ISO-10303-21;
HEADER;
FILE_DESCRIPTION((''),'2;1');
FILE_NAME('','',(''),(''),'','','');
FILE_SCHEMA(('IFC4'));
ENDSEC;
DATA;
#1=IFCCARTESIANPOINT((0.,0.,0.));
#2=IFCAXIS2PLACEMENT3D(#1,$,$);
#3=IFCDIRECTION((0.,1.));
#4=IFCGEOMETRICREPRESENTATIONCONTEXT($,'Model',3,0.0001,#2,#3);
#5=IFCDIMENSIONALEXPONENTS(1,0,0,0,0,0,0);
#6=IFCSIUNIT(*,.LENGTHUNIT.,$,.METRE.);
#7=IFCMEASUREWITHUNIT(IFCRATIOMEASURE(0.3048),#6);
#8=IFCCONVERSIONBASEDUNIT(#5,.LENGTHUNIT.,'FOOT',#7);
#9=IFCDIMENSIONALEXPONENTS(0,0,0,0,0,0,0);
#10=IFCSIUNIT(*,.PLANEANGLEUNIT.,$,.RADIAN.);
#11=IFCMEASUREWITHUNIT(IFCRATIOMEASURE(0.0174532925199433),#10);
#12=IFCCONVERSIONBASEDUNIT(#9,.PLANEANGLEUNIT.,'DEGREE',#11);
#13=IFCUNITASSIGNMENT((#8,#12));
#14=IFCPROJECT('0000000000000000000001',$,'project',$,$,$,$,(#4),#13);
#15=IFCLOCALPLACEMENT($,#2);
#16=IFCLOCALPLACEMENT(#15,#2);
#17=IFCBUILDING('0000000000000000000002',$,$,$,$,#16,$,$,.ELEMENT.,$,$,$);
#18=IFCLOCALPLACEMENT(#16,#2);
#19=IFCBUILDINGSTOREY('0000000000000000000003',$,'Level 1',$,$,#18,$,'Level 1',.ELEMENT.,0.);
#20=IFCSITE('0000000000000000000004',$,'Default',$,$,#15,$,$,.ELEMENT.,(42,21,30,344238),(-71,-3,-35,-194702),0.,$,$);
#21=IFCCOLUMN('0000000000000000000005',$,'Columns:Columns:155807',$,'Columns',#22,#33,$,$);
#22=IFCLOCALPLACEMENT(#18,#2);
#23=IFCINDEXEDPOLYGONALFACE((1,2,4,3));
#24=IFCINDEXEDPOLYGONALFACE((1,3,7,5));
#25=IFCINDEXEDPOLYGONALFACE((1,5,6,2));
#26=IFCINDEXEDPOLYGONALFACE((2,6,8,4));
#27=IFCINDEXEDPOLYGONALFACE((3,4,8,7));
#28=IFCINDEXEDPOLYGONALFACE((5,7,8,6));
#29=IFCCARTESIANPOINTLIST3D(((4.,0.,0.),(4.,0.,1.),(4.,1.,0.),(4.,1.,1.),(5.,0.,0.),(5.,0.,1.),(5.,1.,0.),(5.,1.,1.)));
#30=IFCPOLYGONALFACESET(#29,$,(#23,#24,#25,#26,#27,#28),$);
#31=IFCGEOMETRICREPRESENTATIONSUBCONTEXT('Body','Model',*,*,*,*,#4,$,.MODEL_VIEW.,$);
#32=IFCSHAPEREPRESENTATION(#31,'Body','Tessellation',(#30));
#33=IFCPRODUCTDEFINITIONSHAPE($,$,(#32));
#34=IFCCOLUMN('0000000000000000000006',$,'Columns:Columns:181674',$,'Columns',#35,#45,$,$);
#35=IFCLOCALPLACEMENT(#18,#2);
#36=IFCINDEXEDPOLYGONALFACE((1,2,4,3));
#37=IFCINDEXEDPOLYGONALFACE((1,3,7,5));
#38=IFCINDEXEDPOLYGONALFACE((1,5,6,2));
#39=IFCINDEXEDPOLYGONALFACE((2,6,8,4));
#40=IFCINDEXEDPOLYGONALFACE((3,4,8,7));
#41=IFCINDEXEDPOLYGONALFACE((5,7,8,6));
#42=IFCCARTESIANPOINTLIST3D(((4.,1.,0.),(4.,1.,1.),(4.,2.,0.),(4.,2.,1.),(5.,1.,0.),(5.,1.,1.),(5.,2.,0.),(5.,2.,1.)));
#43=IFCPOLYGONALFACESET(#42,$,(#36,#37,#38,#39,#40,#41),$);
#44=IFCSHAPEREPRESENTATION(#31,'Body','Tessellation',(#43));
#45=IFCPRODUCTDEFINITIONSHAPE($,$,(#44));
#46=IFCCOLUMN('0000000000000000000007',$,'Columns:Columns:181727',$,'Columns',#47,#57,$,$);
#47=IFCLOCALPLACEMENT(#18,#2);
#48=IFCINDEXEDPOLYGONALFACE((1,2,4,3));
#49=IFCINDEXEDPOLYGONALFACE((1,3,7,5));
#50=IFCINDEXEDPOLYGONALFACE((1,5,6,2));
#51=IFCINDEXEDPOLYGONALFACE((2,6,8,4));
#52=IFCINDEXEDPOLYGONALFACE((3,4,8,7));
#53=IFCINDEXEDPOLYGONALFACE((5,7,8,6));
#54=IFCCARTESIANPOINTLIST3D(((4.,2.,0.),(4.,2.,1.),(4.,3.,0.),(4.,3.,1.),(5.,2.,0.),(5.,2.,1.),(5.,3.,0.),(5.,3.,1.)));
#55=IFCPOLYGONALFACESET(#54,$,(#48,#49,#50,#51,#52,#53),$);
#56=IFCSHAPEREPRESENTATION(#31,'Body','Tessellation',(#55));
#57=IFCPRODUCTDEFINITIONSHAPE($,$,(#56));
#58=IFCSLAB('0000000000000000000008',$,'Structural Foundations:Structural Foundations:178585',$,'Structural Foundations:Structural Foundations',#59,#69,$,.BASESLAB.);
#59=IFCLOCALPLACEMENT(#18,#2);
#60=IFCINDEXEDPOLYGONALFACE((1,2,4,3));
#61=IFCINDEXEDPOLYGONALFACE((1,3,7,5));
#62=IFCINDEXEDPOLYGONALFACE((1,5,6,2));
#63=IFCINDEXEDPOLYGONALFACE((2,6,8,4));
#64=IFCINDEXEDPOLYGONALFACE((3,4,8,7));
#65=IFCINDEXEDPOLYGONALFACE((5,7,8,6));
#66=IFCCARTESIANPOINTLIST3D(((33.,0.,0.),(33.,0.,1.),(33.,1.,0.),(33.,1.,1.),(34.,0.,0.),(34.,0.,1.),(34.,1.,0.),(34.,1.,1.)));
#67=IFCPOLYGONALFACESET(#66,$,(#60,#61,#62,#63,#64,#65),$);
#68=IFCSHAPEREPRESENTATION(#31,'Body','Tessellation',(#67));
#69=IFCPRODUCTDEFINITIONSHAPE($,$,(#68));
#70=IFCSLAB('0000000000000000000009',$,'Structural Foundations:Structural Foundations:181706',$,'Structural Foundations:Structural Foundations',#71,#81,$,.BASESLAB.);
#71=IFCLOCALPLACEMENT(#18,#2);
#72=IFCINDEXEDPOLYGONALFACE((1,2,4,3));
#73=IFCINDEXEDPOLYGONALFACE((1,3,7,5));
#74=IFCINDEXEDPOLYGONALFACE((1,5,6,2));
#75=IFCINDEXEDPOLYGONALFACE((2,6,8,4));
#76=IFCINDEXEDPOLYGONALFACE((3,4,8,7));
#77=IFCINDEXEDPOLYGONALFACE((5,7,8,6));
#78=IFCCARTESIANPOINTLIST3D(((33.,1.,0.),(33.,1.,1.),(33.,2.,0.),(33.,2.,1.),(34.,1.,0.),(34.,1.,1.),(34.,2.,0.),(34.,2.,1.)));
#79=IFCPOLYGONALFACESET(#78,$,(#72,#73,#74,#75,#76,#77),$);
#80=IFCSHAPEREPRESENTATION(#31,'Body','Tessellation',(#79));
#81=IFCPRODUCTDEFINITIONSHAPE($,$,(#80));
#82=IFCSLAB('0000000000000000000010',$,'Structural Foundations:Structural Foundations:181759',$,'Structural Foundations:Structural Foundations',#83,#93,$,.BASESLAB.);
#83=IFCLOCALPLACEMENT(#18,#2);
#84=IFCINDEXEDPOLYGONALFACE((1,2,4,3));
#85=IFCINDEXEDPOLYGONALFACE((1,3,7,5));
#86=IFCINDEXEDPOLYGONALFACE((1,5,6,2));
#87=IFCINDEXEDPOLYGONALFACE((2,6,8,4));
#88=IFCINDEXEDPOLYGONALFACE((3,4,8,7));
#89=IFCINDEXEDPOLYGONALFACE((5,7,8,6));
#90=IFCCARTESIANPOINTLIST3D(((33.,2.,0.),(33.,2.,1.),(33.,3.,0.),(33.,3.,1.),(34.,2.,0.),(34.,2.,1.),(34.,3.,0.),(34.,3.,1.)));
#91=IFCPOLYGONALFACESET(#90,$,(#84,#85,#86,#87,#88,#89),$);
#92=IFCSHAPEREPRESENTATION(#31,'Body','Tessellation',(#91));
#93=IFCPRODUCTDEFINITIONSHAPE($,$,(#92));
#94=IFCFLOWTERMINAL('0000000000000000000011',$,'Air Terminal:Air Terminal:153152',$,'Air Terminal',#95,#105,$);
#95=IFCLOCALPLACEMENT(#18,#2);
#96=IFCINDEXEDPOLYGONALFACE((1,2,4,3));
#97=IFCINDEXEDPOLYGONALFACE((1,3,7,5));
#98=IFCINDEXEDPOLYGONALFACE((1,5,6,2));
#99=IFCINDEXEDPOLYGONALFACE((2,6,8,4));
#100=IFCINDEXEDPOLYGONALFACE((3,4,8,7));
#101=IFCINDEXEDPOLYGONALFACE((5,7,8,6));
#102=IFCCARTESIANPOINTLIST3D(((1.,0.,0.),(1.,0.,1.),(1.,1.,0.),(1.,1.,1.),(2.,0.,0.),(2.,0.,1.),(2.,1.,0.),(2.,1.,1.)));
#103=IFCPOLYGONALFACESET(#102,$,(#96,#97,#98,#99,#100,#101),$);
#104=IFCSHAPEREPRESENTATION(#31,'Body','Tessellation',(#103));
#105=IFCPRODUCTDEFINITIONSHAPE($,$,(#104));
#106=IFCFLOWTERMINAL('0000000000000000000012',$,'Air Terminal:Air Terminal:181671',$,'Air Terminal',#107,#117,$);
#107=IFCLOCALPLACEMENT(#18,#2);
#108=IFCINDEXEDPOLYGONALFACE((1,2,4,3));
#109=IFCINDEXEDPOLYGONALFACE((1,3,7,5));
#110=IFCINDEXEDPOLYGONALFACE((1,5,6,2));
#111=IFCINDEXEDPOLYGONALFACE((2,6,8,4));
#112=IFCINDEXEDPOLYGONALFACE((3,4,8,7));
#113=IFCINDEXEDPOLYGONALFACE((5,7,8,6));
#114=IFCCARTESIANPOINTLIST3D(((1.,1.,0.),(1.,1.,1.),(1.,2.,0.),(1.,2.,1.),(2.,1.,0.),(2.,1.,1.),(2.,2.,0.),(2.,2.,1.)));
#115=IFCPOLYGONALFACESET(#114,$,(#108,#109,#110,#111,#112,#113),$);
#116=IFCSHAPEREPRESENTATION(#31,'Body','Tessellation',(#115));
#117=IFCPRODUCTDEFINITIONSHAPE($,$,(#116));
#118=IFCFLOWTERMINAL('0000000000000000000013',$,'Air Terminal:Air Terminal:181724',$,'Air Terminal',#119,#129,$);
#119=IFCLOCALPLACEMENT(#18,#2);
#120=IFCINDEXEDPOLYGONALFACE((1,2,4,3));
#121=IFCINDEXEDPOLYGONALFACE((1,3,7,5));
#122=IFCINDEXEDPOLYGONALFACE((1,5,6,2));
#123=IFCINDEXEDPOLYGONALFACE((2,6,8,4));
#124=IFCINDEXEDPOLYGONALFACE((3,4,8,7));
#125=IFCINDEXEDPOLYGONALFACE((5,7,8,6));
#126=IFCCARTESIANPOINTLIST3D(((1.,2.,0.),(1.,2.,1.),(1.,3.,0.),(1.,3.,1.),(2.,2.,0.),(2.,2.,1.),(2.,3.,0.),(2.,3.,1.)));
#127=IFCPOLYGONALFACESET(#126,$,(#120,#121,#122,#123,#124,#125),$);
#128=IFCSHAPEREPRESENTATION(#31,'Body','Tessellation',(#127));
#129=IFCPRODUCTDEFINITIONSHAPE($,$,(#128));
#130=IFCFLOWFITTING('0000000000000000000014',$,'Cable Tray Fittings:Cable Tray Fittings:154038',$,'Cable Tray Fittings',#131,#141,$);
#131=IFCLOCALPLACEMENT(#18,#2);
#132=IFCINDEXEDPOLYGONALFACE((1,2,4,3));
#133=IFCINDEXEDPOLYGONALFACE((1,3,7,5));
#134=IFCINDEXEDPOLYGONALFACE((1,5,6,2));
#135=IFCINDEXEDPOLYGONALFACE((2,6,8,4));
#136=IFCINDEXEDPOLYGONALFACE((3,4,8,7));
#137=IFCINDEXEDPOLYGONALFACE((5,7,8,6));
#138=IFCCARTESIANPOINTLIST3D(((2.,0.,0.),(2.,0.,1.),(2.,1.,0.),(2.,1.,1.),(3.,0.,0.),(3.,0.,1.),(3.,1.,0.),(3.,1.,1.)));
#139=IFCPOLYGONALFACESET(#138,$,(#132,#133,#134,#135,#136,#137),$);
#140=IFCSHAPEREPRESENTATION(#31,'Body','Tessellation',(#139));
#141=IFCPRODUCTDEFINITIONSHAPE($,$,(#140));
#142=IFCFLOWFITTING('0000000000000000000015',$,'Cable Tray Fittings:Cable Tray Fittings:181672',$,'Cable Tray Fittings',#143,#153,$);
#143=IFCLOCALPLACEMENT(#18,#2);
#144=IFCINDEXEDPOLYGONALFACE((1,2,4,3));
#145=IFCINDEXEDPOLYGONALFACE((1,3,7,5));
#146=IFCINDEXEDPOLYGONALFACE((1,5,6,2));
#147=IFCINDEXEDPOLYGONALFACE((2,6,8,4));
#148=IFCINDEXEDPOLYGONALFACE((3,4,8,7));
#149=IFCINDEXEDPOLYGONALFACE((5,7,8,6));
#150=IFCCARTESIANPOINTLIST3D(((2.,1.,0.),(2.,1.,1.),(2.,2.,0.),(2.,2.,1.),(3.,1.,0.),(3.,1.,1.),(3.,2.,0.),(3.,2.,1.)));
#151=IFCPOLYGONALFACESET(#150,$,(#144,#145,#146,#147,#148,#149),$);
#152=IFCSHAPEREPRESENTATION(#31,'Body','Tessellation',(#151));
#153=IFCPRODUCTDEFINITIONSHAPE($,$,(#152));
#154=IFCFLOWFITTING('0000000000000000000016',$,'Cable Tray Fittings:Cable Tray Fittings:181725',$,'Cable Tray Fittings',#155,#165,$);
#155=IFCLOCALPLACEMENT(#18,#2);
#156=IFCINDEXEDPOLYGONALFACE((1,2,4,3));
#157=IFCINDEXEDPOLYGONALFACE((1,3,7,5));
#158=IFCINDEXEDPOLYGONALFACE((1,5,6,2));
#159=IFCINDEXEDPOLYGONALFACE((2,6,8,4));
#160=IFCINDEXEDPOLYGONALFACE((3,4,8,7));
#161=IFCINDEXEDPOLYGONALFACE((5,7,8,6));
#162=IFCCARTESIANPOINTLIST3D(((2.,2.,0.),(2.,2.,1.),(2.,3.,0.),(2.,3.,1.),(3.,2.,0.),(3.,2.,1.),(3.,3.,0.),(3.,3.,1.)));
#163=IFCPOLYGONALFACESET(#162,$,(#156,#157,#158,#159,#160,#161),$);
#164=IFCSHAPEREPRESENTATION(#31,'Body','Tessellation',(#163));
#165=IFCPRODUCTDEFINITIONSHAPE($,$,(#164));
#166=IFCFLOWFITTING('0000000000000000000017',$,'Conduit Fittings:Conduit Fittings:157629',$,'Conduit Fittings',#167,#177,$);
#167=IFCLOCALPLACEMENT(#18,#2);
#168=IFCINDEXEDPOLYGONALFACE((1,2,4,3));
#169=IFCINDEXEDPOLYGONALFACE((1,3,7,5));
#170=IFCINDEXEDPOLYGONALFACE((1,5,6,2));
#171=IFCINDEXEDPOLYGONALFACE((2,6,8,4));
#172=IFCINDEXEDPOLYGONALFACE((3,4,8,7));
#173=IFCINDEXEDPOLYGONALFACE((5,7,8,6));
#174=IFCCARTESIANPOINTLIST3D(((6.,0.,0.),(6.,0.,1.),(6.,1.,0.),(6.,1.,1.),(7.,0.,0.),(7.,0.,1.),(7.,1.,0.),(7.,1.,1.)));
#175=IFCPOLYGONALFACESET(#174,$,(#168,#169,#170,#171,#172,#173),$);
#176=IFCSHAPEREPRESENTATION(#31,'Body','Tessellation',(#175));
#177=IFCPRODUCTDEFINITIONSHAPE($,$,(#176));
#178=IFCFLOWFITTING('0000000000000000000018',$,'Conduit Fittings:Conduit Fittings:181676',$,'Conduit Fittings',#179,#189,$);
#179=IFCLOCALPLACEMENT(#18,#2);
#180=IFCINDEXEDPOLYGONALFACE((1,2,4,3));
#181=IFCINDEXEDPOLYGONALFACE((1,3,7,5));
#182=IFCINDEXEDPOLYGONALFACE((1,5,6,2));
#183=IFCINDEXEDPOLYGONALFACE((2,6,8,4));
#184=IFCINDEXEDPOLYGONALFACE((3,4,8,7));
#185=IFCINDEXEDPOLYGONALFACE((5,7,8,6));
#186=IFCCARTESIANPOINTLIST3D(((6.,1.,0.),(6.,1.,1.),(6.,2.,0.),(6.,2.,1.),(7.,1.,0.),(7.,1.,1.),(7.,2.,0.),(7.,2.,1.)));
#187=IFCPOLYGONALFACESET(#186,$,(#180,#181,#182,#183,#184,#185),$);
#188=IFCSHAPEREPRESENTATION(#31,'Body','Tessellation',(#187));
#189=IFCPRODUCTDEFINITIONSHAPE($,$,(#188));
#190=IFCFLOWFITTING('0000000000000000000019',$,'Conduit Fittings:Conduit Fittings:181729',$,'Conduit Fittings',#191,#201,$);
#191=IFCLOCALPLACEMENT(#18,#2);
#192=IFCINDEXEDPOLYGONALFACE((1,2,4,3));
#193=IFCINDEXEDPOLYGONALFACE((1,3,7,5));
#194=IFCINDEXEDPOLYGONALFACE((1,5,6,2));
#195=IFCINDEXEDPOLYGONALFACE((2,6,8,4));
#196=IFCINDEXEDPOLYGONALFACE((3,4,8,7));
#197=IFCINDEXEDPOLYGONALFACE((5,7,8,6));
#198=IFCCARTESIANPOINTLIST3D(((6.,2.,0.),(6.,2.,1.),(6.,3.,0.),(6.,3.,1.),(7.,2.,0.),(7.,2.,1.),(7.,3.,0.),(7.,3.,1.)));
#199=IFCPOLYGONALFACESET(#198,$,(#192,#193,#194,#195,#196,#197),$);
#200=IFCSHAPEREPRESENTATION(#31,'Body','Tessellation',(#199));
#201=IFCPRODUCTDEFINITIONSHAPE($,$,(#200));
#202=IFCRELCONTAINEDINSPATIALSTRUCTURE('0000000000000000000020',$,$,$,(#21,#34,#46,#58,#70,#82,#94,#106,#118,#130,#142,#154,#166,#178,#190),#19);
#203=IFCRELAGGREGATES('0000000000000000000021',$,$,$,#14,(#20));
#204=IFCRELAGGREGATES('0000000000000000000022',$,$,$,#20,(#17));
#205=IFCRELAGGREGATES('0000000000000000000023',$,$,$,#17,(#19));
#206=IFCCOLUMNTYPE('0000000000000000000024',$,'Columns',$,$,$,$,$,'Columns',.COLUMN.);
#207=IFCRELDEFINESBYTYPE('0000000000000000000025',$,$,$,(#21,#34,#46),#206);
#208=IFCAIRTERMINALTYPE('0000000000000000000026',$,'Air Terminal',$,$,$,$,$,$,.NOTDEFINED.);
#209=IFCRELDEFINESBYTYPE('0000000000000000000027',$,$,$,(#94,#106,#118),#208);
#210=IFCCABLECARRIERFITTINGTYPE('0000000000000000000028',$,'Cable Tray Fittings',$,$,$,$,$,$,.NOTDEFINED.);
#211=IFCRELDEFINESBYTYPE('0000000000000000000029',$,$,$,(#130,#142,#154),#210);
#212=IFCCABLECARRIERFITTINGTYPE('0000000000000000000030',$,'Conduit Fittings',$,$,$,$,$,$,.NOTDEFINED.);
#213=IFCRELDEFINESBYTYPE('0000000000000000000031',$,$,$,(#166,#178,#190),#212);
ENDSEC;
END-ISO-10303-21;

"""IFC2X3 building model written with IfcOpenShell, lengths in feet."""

from ifc_helpers import new_model, entity, si_unit, converted_unit, direction, frame, frame_2d, origin, origin_2d_with_axis, place, context, subcontext, project, spatial, rectangle, extrude, source, transform, mapped, type_object, type_shapes, element, save


model = new_model("IFC2X3")

# Units and contexts
model_context = context("Model", 3, precision=0.0001, world=origin(), true_north=direction((0.0, 1.0)))
body_context = subcontext(model_context, "Body", "Model", "MODEL_VIEW")
ifc_project = project(units=[converted_unit("LENGTHUNIT", "FOOT", entity("IfcRatioMeasure", 0.3048), si_unit("LENGTHUNIT", "METRE"), dimensions=[1, 0, 0, 0, 0, 0, 0]), converted_unit("PLANEANGLEUNIT", "DEGREE", entity("IfcRatioMeasure", 0.0174532925199433), si_unit("PLANEANGLEUNIT", "RADIAN"), dimensions=[0, 0, 0, 0, 0, 0, 0])], contexts=[model_context])

# Site, building, storey
site_placement = place(None, origin())
site = spatial("IfcSite", under=ifc_project, at=site_placement, Name="Default", CompositionType="ELEMENT", RefLatitude=(42, 21, 30, 344238), RefLongitude=(-71, -3, -35, -194702), RefElevation=0.0)
building_placement = place(site_placement, origin())
building = spatial("IfcBuilding", under=site, at=building_placement, CompositionType="ELEMENT")
storey_placement = place(building_placement, origin())
storey = spatial("IfcBuildingStorey", under=building, at=storey_placement, Name="Level 1", LongName="Level 1", CompositionType="ELEMENT", Elevation=0.0)

# Columns
column_type = type_object("IfcColumnType", Name="Columns", ElementType="Columns", PredefinedType="COLUMN")
shared_shape_1 = source(origin(), body_context, "Body", "SweptSolid", [
    extrude(rectangle(XDim=1.0, YDim=1.0, at=frame_2d((0.0, 0.0), x_axis=(1.0, 0.0))), frame((0.5, 0.5, 0.0), z_axis=(0.0, 0.0, 1.0), x_axis=(0.0, -1.0, 0.0)), (0.0, 0.0, 1.0), 1.0),
])
type_shapes(column_type, [shared_shape_1])
for number, where, name in (
    (1, (4.0, 0.0, 0.0), "Columns:Columns:155807"),
    (2, (4.0, 1.0, 0.0), "Columns:Columns:181674"),
    (3, (4.0, 2.0, 0.0), "Columns:Columns:181727"),
):
    element("IfcColumn", number, at=place(storey_placement, frame(where)), inside=storey, type_object=column_type, Name=name, ObjectType="Columns", context=body_context, shape_type="MappedRepresentation", body=[
        mapped(shared_shape_1, transform((0.0, 0.0, 0.0), scale=1.0)),
    ])

# Slabs
slab_1_placement = place(storey_placement, origin())
element("IfcSlab", 4, at=slab_1_placement, inside=storey, Name="Structural Foundations:Structural Foundations:178585", ObjectType="Structural Foundations:Structural Foundations", PredefinedType="BASESLAB", context=body_context, shape_type="SweptSolid", body=[
    extrude(rectangle(XDim=1.0, YDim=1.0, at=frame_2d((0.0, 0.0), x_axis=(1.0, 0.0))), frame((33.5, 0.5, 0.0), z_axis=(0.0, 0.0, 1.0), x_axis=(0.0, 1.0, 0.0)), (0.0, 0.0, 1.0), 1.0),
])
slab_2_placement = place(storey_placement, origin())
element("IfcSlab", 5, at=slab_2_placement, inside=storey, Name="Structural Foundations:Structural Foundations:181706", ObjectType="Structural Foundations:Structural Foundations", PredefinedType="BASESLAB", context=body_context, shape_type="SweptSolid", body=[
    extrude(rectangle(XDim=1.0, YDim=1.0, at=frame_2d((0.0, 0.0), x_axis=(1.0, 0.0))), frame((33.5, 1.5, 0.0), z_axis=(0.0, 0.0, 1.0), x_axis=(0.0, 1.0, 0.0)), (0.0, 0.0, 1.0), 1.0),
])
slab_3_placement = place(storey_placement, origin())
element("IfcSlab", 6, at=slab_3_placement, inside=storey, Name="Structural Foundations:Structural Foundations:181759", ObjectType="Structural Foundations:Structural Foundations", PredefinedType="BASESLAB", context=body_context, shape_type="SweptSolid", body=[
    extrude(rectangle(XDim=1.0, YDim=1.0, at=origin_2d_with_axis()), frame((33.5, 2.5, 0.0), z_axis=(0.0, 0.0, 1.0), x_axis=(0.0, 1.0, 0.0)), (0.0, 0.0, 1.0), 1.0),
])

# Flow terminals
air_terminal_type = type_object("IfcAirTerminalType", Name="Air Terminal", PredefinedType="NOTDEFINED")
shared_shape_2 = source(origin(), body_context, "Body", "SweptSolid", [
    extrude(rectangle(XDim=1.0, YDim=1.0, at=frame_2d((0.0, 0.0), x_axis=(1.0, 0.0))), frame((0.5, 0.5, 0.0), z_axis=(0.0, 0.0, 1.0), x_axis=(0.0, 1.0, 0.0)), (0.0, 0.0, 1.0), 1.0),
])
type_shapes(air_terminal_type, [shared_shape_2])
for number, where, name in (
    (7, (1.0, 0.0, 0.0), "Air Terminal:Air Terminal:153152"),
    (8, (1.0, 1.0, 0.0), "Air Terminal:Air Terminal:181671"),
    (9, (1.0, 2.0, 0.0), "Air Terminal:Air Terminal:181724"),
):
    element("IfcFlowTerminal", number, at=place(storey_placement, frame(where)), inside=storey, type_object=air_terminal_type, Name=name, ObjectType="Air Terminal", context=body_context, shape_type="MappedRepresentation", body=[
        mapped(shared_shape_2, transform((0.0, 0.0, 0.0), scale=1.0)),
    ])

# Flow fittings
cable_carrier_fitting_type_1 = type_object("IfcCableCarrierFittingType", Name="Cable Tray Fittings", PredefinedType="NOTDEFINED")
shared_shape_3 = source(origin(), body_context, "Body", "SweptSolid", [
    extrude(rectangle(XDim=1.0, YDim=1.0, at=frame_2d((0.0, 0.0), x_axis=(1.0, 0.0))), frame((0.5, 0.5, 0.0), z_axis=(0.0, 0.0, 1.0), x_axis=(0.0, 1.0, 0.0)), (0.0, 0.0, 1.0), 1.0),
])
type_shapes(cable_carrier_fitting_type_1, [shared_shape_3])
for number, where, name in (
    (10, (2.0, 0.0, 0.0), "Cable Tray Fittings:Cable Tray Fittings:154038"),
    (11, (2.0, 1.0, 0.0), "Cable Tray Fittings:Cable Tray Fittings:181672"),
    (12, (2.0, 2.0, 0.0), "Cable Tray Fittings:Cable Tray Fittings:181725"),
):
    element("IfcFlowFitting", number, at=place(storey_placement, frame(where)), inside=storey, type_object=cable_carrier_fitting_type_1, Name=name, ObjectType="Cable Tray Fittings", context=body_context, shape_type="MappedRepresentation", body=[
        mapped(shared_shape_3, transform((0.0, 0.0, 0.0), scale=1.0)),
    ])
cable_carrier_fitting_type_2 = type_object("IfcCableCarrierFittingType", Name="Conduit Fittings", PredefinedType="NOTDEFINED")
shared_shape_4 = source(origin(), body_context, "Body", "SweptSolid", [
    extrude(rectangle(XDim=1.0, YDim=1.0, at=frame_2d((0.0, 0.0), x_axis=(1.0, 0.0))), frame((0.5, 0.5, 0.0), z_axis=(0.0, 0.0, 1.0), x_axis=(0.0, 1.0, 0.0)), (0.0, 0.0, 1.0), 1.0),
])
type_shapes(cable_carrier_fitting_type_2, [shared_shape_4])
for number, where, name in (
    (13, (6.0, 0.0, 0.0), "Conduit Fittings:Conduit Fittings:157629"),
    (14, (6.0, 1.0, 0.0), "Conduit Fittings:Conduit Fittings:181676"),
    (15, (6.0, 2.0, 0.0), "Conduit Fittings:Conduit Fittings:181729"),
):
    element("IfcFlowFitting", number, at=place(storey_placement, frame(where)), inside=storey, type_object=cable_carrier_fitting_type_2, Name=name, ObjectType="Conduit Fittings", context=body_context, shape_type="MappedRepresentation", body=[
        mapped(shared_shape_4, transform((0.0, 0.0, 0.0), scale=1.0)),
    ])

save(model, "model.ifc")
